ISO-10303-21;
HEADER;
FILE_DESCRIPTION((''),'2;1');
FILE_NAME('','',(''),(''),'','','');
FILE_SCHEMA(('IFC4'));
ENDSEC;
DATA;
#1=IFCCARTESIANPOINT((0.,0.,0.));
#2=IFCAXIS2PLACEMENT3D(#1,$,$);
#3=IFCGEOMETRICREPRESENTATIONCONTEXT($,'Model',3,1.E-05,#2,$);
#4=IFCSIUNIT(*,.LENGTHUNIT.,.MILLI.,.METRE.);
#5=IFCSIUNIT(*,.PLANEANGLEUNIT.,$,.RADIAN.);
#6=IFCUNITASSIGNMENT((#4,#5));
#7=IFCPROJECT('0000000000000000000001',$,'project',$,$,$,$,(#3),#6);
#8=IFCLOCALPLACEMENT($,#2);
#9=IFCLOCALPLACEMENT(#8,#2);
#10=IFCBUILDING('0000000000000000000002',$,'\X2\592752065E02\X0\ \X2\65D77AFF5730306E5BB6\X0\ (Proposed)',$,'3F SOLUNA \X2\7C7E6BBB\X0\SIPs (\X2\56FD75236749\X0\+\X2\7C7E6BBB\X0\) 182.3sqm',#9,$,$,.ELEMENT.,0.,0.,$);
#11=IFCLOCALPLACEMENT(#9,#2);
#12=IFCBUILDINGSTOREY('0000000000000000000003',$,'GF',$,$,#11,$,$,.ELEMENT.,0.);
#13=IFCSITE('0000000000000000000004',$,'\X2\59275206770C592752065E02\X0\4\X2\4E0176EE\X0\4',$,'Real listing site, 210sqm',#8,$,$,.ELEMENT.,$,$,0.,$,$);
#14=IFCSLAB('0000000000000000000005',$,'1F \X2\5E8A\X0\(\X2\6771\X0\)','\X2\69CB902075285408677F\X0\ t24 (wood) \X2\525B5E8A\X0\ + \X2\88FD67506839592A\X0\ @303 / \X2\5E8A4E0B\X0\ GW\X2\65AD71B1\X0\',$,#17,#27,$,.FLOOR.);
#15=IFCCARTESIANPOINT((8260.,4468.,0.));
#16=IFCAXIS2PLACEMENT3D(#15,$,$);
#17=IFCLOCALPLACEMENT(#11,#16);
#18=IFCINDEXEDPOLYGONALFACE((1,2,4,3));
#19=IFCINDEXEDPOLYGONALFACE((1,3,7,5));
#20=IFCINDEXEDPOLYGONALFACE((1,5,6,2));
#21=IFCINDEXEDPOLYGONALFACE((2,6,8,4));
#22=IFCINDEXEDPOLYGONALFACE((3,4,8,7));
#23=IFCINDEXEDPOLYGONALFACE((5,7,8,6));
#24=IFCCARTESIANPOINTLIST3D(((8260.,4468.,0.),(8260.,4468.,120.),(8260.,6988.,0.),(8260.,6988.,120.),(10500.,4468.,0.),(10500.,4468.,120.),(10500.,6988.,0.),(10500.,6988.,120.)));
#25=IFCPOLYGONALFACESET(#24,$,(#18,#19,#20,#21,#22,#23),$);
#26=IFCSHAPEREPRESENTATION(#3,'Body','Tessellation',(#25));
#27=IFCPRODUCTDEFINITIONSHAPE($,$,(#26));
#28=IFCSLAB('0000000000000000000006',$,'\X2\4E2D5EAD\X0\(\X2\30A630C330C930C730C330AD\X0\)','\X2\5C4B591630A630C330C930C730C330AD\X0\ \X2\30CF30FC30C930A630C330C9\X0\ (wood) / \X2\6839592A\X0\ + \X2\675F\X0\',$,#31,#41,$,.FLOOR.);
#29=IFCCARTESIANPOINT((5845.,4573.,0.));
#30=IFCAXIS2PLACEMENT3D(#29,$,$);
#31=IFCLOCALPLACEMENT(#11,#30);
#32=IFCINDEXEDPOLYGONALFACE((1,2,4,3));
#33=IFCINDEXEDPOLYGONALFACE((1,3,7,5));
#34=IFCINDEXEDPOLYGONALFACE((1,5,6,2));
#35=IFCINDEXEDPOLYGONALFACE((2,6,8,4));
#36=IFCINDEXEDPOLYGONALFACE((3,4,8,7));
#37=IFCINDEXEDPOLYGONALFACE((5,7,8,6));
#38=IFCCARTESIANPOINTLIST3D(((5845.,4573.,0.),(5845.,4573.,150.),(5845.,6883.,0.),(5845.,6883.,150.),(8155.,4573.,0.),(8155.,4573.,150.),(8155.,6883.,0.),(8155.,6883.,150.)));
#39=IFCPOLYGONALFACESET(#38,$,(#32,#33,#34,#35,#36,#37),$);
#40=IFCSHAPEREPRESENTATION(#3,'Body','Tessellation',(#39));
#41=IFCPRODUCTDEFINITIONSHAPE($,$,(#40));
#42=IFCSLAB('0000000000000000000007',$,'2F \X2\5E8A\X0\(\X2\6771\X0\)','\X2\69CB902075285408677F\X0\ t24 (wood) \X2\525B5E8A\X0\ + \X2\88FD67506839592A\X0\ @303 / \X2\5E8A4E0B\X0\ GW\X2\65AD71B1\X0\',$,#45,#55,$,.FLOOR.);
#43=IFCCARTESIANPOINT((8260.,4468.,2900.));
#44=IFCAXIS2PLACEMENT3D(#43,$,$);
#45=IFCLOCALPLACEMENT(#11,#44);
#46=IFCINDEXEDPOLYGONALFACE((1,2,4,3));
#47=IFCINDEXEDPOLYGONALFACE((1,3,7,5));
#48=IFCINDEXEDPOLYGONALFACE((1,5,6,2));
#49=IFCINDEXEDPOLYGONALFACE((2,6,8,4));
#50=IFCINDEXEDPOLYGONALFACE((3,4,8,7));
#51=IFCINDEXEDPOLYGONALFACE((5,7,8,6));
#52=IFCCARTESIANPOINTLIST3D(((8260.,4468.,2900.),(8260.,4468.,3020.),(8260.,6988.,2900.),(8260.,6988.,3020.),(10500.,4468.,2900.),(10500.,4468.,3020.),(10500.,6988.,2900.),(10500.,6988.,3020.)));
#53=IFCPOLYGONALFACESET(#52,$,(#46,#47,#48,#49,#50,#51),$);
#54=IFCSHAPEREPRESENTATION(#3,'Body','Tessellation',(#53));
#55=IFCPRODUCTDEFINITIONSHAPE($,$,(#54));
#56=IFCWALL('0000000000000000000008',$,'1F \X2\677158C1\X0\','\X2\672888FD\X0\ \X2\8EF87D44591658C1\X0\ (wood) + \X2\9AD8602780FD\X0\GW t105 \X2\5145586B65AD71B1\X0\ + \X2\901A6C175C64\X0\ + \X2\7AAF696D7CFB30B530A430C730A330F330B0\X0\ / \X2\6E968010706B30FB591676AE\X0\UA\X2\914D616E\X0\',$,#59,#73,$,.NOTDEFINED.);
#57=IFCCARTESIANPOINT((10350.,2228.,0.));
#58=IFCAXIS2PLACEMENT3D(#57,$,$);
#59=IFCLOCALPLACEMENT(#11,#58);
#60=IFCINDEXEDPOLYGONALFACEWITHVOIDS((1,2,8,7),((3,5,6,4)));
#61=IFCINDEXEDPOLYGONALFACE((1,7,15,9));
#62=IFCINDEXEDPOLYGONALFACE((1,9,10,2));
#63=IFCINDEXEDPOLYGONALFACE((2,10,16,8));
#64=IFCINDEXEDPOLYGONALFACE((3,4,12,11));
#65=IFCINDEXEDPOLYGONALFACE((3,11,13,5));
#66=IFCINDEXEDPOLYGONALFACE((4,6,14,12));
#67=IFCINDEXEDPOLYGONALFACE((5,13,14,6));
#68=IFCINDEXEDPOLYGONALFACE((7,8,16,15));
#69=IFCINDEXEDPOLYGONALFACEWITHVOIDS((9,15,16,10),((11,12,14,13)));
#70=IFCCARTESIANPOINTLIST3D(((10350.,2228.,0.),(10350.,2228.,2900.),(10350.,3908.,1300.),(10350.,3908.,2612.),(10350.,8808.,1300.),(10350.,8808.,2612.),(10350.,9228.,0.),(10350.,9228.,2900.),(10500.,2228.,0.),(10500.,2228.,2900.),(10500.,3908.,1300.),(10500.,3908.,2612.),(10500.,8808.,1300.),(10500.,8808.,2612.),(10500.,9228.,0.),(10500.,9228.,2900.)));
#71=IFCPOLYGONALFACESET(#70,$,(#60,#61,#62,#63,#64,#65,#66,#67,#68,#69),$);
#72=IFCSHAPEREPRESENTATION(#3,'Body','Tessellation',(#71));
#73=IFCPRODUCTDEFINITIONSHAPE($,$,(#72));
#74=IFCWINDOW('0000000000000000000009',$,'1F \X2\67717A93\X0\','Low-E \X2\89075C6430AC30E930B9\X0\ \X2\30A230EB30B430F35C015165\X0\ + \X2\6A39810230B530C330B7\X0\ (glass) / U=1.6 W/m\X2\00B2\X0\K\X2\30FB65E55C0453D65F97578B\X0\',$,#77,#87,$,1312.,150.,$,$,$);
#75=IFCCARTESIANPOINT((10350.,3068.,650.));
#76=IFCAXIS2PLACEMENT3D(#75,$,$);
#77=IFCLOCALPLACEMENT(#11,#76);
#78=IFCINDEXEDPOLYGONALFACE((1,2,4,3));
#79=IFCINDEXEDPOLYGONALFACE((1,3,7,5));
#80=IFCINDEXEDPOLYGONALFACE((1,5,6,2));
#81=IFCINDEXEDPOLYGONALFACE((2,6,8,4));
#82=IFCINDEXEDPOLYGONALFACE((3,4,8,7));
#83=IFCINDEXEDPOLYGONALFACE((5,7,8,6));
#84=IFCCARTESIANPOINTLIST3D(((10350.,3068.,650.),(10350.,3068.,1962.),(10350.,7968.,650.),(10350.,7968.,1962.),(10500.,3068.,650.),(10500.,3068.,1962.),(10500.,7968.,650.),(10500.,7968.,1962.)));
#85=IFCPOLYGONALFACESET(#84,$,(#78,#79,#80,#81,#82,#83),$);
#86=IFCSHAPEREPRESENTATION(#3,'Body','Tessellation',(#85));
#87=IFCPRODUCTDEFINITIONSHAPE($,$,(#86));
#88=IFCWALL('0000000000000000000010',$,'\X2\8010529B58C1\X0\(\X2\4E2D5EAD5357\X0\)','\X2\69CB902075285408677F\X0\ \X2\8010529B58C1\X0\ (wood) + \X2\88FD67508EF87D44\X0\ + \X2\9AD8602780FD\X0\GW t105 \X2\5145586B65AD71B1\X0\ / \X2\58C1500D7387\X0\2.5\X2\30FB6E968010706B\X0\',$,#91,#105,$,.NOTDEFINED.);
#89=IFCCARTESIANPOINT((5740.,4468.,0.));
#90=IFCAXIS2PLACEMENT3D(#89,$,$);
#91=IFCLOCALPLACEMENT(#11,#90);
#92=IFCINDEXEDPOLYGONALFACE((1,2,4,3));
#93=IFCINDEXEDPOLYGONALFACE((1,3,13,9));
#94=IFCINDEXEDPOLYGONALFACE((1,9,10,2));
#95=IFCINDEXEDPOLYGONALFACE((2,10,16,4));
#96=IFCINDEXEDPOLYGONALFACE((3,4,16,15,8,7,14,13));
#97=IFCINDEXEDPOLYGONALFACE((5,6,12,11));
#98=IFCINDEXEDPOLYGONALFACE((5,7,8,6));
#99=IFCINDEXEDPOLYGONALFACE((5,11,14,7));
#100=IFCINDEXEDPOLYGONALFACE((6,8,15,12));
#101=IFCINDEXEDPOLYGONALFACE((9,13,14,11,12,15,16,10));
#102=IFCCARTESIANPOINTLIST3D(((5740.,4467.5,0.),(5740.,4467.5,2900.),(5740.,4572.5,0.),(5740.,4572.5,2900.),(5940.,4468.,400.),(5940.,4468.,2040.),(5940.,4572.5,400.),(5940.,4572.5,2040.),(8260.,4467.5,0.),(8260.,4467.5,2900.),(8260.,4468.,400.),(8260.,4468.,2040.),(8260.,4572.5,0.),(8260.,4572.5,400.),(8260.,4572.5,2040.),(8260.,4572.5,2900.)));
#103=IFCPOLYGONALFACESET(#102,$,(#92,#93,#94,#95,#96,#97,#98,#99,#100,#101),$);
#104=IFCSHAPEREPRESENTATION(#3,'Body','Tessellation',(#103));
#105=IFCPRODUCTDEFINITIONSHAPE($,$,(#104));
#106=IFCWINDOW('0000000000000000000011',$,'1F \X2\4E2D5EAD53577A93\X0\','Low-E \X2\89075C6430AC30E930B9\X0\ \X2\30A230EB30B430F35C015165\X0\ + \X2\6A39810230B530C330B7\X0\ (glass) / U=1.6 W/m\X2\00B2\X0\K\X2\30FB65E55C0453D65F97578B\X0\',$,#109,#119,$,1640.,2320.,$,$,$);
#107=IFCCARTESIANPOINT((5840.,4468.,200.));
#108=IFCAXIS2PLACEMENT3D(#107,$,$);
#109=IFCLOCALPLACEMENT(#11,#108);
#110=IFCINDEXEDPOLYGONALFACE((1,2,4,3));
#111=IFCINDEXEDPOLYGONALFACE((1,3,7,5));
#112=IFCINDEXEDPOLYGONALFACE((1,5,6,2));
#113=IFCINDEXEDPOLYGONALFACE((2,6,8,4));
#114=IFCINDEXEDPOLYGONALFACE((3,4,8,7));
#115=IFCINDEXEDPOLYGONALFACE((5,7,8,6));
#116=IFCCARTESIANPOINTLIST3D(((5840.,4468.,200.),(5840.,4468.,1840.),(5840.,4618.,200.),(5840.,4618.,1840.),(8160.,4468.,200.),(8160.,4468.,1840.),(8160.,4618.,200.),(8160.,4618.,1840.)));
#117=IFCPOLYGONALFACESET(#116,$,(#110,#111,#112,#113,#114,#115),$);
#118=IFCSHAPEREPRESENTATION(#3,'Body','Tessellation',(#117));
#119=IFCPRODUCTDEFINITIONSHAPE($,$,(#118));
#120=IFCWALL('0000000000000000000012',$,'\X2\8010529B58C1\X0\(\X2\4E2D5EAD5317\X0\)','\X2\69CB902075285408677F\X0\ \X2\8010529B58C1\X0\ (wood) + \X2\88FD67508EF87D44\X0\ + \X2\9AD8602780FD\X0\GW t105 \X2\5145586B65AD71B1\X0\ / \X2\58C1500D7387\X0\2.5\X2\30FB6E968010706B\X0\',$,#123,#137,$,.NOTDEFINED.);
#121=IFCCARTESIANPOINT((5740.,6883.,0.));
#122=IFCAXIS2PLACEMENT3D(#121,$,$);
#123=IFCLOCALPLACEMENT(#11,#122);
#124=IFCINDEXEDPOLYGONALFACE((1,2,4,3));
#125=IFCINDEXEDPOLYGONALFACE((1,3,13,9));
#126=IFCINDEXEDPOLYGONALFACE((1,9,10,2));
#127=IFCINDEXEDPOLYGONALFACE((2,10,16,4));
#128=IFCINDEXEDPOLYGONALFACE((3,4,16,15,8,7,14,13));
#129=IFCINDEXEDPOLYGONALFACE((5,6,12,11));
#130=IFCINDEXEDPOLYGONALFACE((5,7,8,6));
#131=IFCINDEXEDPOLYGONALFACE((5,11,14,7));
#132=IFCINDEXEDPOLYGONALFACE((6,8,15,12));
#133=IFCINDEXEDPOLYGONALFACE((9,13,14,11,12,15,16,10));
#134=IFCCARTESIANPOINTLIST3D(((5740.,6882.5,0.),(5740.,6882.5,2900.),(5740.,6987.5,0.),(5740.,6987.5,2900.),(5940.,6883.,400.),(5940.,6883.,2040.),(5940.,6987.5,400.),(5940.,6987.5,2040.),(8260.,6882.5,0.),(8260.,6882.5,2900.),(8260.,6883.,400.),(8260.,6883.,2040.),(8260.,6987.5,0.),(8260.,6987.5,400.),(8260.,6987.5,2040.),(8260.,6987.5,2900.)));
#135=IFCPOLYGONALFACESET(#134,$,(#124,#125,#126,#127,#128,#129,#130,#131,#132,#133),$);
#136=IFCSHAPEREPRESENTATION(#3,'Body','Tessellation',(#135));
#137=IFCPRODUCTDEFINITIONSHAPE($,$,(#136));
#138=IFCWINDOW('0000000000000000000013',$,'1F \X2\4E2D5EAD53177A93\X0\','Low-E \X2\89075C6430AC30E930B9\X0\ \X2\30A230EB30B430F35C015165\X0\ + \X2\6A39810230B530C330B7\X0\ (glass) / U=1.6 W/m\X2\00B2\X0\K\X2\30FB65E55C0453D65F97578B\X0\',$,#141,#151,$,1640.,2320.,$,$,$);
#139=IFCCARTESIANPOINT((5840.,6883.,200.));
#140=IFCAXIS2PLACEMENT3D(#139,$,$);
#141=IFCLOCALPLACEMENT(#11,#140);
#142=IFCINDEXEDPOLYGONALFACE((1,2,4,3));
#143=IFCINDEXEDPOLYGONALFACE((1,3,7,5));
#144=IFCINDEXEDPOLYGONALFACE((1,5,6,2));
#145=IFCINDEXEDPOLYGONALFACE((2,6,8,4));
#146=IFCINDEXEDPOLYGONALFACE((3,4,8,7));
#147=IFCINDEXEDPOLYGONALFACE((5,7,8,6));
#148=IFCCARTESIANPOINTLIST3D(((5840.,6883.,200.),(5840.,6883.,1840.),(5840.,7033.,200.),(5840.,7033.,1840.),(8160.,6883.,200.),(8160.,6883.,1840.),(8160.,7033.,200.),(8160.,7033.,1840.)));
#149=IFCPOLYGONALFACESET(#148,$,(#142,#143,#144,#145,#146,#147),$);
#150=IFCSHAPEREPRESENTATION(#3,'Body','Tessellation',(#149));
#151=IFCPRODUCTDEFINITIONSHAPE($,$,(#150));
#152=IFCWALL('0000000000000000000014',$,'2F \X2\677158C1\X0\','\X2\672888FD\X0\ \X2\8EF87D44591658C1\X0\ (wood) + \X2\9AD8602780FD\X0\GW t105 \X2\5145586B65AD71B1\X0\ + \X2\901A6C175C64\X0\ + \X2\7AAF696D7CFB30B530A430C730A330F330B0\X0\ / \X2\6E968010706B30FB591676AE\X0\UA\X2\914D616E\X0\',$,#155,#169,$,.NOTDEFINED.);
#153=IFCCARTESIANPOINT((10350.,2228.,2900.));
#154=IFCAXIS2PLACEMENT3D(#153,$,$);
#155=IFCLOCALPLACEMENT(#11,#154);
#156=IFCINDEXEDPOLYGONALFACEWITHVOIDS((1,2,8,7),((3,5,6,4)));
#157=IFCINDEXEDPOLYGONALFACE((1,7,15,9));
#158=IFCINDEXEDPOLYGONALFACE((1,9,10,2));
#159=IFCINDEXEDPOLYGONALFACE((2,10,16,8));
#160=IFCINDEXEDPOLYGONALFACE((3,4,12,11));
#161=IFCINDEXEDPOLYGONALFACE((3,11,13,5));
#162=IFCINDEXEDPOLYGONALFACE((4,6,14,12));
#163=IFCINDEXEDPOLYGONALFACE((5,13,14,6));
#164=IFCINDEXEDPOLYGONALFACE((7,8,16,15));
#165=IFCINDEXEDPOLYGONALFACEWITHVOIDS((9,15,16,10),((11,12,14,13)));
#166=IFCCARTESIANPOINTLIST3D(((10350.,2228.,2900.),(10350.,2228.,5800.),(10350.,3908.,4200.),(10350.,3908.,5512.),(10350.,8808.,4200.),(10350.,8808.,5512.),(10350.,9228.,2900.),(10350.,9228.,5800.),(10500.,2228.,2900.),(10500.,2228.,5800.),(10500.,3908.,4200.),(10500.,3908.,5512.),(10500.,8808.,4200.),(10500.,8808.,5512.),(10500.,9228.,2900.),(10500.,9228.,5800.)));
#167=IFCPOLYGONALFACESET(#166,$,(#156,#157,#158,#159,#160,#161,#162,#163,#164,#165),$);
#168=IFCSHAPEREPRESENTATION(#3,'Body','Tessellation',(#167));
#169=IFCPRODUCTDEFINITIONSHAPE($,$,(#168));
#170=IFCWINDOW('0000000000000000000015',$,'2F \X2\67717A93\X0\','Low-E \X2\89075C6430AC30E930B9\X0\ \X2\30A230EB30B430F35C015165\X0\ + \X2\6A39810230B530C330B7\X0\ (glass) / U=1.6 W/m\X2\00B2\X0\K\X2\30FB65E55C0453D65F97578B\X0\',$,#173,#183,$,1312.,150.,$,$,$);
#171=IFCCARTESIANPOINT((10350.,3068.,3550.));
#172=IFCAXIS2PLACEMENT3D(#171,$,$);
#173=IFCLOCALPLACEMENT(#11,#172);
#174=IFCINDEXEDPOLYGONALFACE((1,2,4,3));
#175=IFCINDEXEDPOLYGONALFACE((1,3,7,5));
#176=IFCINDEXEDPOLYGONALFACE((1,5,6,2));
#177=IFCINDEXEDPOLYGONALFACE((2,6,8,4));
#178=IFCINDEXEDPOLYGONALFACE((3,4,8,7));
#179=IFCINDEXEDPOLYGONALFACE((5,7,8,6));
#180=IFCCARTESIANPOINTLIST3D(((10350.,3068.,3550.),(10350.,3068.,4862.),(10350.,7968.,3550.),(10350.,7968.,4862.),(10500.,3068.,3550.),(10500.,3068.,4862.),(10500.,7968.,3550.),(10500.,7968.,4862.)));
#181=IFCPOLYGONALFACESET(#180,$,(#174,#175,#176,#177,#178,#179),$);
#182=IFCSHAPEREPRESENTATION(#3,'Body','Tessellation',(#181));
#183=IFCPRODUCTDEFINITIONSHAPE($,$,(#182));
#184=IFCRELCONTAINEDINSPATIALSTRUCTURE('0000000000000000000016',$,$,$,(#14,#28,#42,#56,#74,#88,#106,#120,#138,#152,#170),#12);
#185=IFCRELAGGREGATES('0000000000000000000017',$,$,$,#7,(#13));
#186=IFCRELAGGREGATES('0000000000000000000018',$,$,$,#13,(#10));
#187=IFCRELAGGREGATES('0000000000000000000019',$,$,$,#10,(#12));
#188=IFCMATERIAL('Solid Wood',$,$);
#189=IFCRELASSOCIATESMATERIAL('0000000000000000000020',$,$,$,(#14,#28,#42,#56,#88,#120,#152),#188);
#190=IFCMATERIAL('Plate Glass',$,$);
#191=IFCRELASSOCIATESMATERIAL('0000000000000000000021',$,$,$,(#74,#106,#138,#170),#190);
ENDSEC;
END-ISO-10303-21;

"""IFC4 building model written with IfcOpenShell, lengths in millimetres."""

from ifc_helpers import new_model, si_unit, frame, frame_2d, origin, place, context, project, spatial, rectangle, extrude, material, element, fill, save


model = new_model("IFC4")

# Units and contexts
model_context = context("Model", 3, precision=1e-05, world=origin())
ifc_project = project(units=[si_unit("LENGTHUNIT", "METRE", prefix="MILLI"), si_unit("PLANEANGLEUNIT", "RADIAN")], contexts=[model_context])

# Site, building, storey
site_placement = place(None, origin())
site = spatial("IfcSite", under=ifc_project, at=site_placement, Name="大分県大分市4丁目4", ObjectType="Real listing site, 210sqm", CompositionType="ELEMENT", RefElevation=0.0)
building_placement = place(site_placement, origin())
building = spatial("IfcBuilding", under=site, at=building_placement, Name="大分市 旗竿地の家 (Proposed)", ObjectType="3F SOLUNA 籾殻SIPs (国産杉+籾殻) 182.3sqm", CompositionType="ELEMENT", ElevationOfRefHeight=0.0, ElevationOfTerrain=0.0)
storey_placement = place(building_placement, origin())
storey = spatial("IfcBuildingStorey", under=building, at=storey_placement, Name="GF", CompositionType="ELEMENT", Elevation=0.0)

# Slabs
ifc_material_1 = material(Name="Solid Wood")
slab_1_placement = place(storey_placement, frame((8260.0, 4468.0, 0.0)))
element("IfcSlab", 1, at=slab_1_placement, inside=storey, material=ifc_material_1, Name="1F 床(東)", Description="構造用合板 t24 (wood) 剛床 + 製材根太 @303 / 床下 GW断熱", PredefinedType="FLOOR", context=model_context, shape_type="SweptSolid", body=[
    extrude(rectangle(XDim=2240.0, YDim=2520.0, at=frame_2d((1120.0, 1260.0))), frame((8260.0, 4468.0, 0.0)), (0.0, 0.0, 1.0), 120.0),
])
slab_2_placement = place(storey_placement, frame((5845.0, 4573.0, 0.0)))
element("IfcSlab", 2, at=slab_2_placement, inside=storey, material=ifc_material_1, Name="中庭(ウッドデッキ)", Description="屋外ウッドデッキ ハードウッド (wood) / 根太 + 束", PredefinedType="FLOOR", context=model_context, shape_type="SweptSolid", body=[
    extrude(rectangle(XDim=2310.0, YDim=2310.0, at=frame_2d((1155.0, 1155.0))), frame((5845.0, 4573.0, 0.0)), (0.0, 0.0, 1.0), 150.0),
])
slab_3_placement = place(storey_placement, frame((8260.0, 4468.0, 2900.0)))
element("IfcSlab", 3, at=slab_3_placement, inside=storey, material=ifc_material_1, Name="2F 床(東)", Description="構造用合板 t24 (wood) 剛床 + 製材根太 @303 / 床下 GW断熱", PredefinedType="FLOOR", context=model_context, shape_type="SweptSolid", body=[
    extrude(rectangle(XDim=2240.0, YDim=2520.0, at=frame_2d((1120.0, 1260.0))), frame((8260.0, 4468.0, 2900.0)), (0.0, 0.0, 1.0), 120.0),
])

# Walls, openings, windows
wall_1_placement = place(storey_placement, frame((10350.0, 2228.0, 0.0)))
wall_1 = element("IfcWall", 4, at=wall_1_placement, inside=storey, material=ifc_material_1, Name="1F 東壁", Description="木製 軸組外壁 (wood) + 高性能GW t105 充填断熱 + 通気層 + 窯業系サイディング / 準耐火・外皮UA配慮", PredefinedType="NOTDEFINED", context=model_context, shape_type="SweptSolid", body=[
    extrude(rectangle(XDim=150.0, YDim=7000.0, at=frame_2d((75.0, 3500.0))), frame((10350.0, 2228.0, 0.0)), (0.0, 0.0, 1.0), 2900.0),
])
opening_1_placement = place(storey_placement, frame((10350.0, 3068.0, 650.0)))
opening_1 = element("IfcOpeningElement", 5, at=opening_1_placement, cuts=wall_1, PredefinedType="NOTDEFINED", context=model_context, shape_type="SweptSolid", body=[
    extrude(rectangle(XDim=150.0, YDim=4900.0, at=frame_2d((75.0, 2450.0))), frame((10350.0, 3068.0, 650.0)), (0.0, 0.0, 1.0), 1312.0),
])
ifc_material_2 = material(Name="Plate Glass")
window_1_placement = place(storey_placement, frame((10350.0, 3068.0, 650.0)))
window_1 = element("IfcWindow", 6, at=window_1_placement, inside=storey, material=ifc_material_2, Name="1F 東窓", Description="Low-E 複層ガラス アルゴン封入 + 樹脂サッシ (glass) / U=1.6 W/m²K・日射取得型", OverallHeight=1312.0, OverallWidth=150.0, context=model_context, shape_type="SweptSolid", body=[
    extrude(rectangle(XDim=150.0, YDim=4900.0, at=frame_2d((75.0, 2450.0))), frame((10350.0, 3068.0, 650.0)), (0.0, 0.0, 1.0), 1312.0),
])
fill(opening_1, window_1)
wall_2_placement = place(storey_placement, frame((5740.0, 4468.0, 0.0)))
wall_2 = element("IfcWall", 7, at=wall_2_placement, inside=storey, material=ifc_material_1, Name="耐力壁(中庭南)", Description="構造用合板 耐力壁 (wood) + 製材軸組 + 高性能GW t105 充填断熱 / 壁倍率2.5・準耐火", PredefinedType="NOTDEFINED", context=model_context, shape_type="SweptSolid", body=[
    extrude(rectangle(XDim=2520.0, YDim=105.0, at=frame_2d((1260.0, 52.0))), frame((5740.0, 4468.0, 0.0)), (0.0, 0.0, 1.0), 2900.0),
])
opening_2_placement = place(storey_placement, frame((5840.0, 4468.0, 200.0)))
opening_2 = element("IfcOpeningElement", 8, at=opening_2_placement, cuts=wall_2, PredefinedType="NOTDEFINED", context=model_context, shape_type="SweptSolid", body=[
    extrude(rectangle(XDim=2320.0, YDim=150.0, at=frame_2d((1160.0, 75.0))), frame((5840.0, 4468.0, 200.0)), (0.0, 0.0, 1.0), 1640.0),
])
window_2_placement = place(storey_placement, frame((5840.0, 4468.0, 200.0)))
window_2 = element("IfcWindow", 9, at=window_2_placement, inside=storey, material=ifc_material_2, Name="1F 中庭南窓", Description="Low-E 複層ガラス アルゴン封入 + 樹脂サッシ (glass) / U=1.6 W/m²K・日射取得型", OverallHeight=1640.0, OverallWidth=2320.0, context=model_context, shape_type="SweptSolid", body=[
    extrude(rectangle(XDim=2320.0, YDim=150.0, at=frame_2d((1160.0, 75.0))), frame((5840.0, 4468.0, 200.0)), (0.0, 0.0, 1.0), 1640.0),
])
fill(opening_2, window_2)
wall_3_placement = place(storey_placement, frame((5740.0, 6883.0, 0.0)))
wall_3 = element("IfcWall", 10, at=wall_3_placement, inside=storey, material=ifc_material_1, Name="耐力壁(中庭北)", Description="構造用合板 耐力壁 (wood) + 製材軸組 + 高性能GW t105 充填断熱 / 壁倍率2.5・準耐火", PredefinedType="NOTDEFINED", context=model_context, shape_type="SweptSolid", body=[
    extrude(rectangle(XDim=2520.0, YDim=105.0, at=frame_2d((1260.0, 52.0))), frame((5740.0, 6883.0, 0.0)), (0.0, 0.0, 1.0), 2900.0),
])
opening_3_placement = place(storey_placement, frame((5840.0, 6883.0, 200.0)))
opening_3 = element("IfcOpeningElement", 11, at=opening_3_placement, cuts=wall_3, PredefinedType="NOTDEFINED", context=model_context, shape_type="SweptSolid", body=[
    extrude(rectangle(XDim=2320.0, YDim=150.0, at=frame_2d((1160.0, 75.0))), frame((5840.0, 6883.0, 200.0)), (0.0, 0.0, 1.0), 1640.0),
])
window_3_placement = place(storey_placement, frame((5840.0, 6883.0, 200.0)))
window_3 = element("IfcWindow", 12, at=window_3_placement, inside=storey, material=ifc_material_2, Name="1F 中庭北窓", Description="Low-E 複層ガラス アルゴン封入 + 樹脂サッシ (glass) / U=1.6 W/m²K・日射取得型", OverallHeight=1640.0, OverallWidth=2320.0, context=model_context, shape_type="SweptSolid", body=[
    extrude(rectangle(XDim=2320.0, YDim=150.0, at=frame_2d((1160.0, 75.0))), frame((5840.0, 6883.0, 200.0)), (0.0, 0.0, 1.0), 1640.0),
])
fill(opening_3, window_3)

# Wall, opening, window
wall_4_placement = place(storey_placement, frame((10350.0, 2228.0, 2900.0)))
wall_4 = element("IfcWall", 13, at=wall_4_placement, inside=storey, material=ifc_material_1, Name="2F 東壁", Description="木製 軸組外壁 (wood) + 高性能GW t105 充填断熱 + 通気層 + 窯業系サイディング / 準耐火・外皮UA配慮", PredefinedType="NOTDEFINED", context=model_context, shape_type="SweptSolid", body=[
    extrude(rectangle(XDim=150.0, YDim=7000.0, at=frame_2d((75.0, 3500.0))), frame((10350.0, 2228.0, 2900.0)), (0.0, 0.0, 1.0), 2900.0),
])
opening_4_placement = place(storey_placement, frame((10350.0, 3068.0, 3550.0)))
opening_4 = element("IfcOpeningElement", 14, at=opening_4_placement, cuts=wall_4, PredefinedType="NOTDEFINED", context=model_context, shape_type="SweptSolid", body=[
    extrude(rectangle(XDim=150.0, YDim=4900.0, at=frame_2d((75.0, 2450.0))), frame((10350.0, 3068.0, 3550.0)), (0.0, 0.0, 1.0), 1312.0),
])
window_4_placement = place(storey_placement, frame((10350.0, 3068.0, 3550.0)))
window_4 = element("IfcWindow", 15, at=window_4_placement, inside=storey, material=ifc_material_2, Name="2F 東窓", Description="Low-E 複層ガラス アルゴン封入 + 樹脂サッシ (glass) / U=1.6 W/m²K・日射取得型", OverallHeight=1312.0, OverallWidth=150.0, context=model_context, shape_type="SweptSolid", body=[
    extrude(rectangle(XDim=150.0, YDim=4900.0, at=frame_2d((75.0, 2450.0))), frame((10350.0, 3068.0, 3550.0)), (0.0, 0.0, 1.0), 1312.0),
])
fill(opening_4, window_4)

save(model, "model.ifc")
